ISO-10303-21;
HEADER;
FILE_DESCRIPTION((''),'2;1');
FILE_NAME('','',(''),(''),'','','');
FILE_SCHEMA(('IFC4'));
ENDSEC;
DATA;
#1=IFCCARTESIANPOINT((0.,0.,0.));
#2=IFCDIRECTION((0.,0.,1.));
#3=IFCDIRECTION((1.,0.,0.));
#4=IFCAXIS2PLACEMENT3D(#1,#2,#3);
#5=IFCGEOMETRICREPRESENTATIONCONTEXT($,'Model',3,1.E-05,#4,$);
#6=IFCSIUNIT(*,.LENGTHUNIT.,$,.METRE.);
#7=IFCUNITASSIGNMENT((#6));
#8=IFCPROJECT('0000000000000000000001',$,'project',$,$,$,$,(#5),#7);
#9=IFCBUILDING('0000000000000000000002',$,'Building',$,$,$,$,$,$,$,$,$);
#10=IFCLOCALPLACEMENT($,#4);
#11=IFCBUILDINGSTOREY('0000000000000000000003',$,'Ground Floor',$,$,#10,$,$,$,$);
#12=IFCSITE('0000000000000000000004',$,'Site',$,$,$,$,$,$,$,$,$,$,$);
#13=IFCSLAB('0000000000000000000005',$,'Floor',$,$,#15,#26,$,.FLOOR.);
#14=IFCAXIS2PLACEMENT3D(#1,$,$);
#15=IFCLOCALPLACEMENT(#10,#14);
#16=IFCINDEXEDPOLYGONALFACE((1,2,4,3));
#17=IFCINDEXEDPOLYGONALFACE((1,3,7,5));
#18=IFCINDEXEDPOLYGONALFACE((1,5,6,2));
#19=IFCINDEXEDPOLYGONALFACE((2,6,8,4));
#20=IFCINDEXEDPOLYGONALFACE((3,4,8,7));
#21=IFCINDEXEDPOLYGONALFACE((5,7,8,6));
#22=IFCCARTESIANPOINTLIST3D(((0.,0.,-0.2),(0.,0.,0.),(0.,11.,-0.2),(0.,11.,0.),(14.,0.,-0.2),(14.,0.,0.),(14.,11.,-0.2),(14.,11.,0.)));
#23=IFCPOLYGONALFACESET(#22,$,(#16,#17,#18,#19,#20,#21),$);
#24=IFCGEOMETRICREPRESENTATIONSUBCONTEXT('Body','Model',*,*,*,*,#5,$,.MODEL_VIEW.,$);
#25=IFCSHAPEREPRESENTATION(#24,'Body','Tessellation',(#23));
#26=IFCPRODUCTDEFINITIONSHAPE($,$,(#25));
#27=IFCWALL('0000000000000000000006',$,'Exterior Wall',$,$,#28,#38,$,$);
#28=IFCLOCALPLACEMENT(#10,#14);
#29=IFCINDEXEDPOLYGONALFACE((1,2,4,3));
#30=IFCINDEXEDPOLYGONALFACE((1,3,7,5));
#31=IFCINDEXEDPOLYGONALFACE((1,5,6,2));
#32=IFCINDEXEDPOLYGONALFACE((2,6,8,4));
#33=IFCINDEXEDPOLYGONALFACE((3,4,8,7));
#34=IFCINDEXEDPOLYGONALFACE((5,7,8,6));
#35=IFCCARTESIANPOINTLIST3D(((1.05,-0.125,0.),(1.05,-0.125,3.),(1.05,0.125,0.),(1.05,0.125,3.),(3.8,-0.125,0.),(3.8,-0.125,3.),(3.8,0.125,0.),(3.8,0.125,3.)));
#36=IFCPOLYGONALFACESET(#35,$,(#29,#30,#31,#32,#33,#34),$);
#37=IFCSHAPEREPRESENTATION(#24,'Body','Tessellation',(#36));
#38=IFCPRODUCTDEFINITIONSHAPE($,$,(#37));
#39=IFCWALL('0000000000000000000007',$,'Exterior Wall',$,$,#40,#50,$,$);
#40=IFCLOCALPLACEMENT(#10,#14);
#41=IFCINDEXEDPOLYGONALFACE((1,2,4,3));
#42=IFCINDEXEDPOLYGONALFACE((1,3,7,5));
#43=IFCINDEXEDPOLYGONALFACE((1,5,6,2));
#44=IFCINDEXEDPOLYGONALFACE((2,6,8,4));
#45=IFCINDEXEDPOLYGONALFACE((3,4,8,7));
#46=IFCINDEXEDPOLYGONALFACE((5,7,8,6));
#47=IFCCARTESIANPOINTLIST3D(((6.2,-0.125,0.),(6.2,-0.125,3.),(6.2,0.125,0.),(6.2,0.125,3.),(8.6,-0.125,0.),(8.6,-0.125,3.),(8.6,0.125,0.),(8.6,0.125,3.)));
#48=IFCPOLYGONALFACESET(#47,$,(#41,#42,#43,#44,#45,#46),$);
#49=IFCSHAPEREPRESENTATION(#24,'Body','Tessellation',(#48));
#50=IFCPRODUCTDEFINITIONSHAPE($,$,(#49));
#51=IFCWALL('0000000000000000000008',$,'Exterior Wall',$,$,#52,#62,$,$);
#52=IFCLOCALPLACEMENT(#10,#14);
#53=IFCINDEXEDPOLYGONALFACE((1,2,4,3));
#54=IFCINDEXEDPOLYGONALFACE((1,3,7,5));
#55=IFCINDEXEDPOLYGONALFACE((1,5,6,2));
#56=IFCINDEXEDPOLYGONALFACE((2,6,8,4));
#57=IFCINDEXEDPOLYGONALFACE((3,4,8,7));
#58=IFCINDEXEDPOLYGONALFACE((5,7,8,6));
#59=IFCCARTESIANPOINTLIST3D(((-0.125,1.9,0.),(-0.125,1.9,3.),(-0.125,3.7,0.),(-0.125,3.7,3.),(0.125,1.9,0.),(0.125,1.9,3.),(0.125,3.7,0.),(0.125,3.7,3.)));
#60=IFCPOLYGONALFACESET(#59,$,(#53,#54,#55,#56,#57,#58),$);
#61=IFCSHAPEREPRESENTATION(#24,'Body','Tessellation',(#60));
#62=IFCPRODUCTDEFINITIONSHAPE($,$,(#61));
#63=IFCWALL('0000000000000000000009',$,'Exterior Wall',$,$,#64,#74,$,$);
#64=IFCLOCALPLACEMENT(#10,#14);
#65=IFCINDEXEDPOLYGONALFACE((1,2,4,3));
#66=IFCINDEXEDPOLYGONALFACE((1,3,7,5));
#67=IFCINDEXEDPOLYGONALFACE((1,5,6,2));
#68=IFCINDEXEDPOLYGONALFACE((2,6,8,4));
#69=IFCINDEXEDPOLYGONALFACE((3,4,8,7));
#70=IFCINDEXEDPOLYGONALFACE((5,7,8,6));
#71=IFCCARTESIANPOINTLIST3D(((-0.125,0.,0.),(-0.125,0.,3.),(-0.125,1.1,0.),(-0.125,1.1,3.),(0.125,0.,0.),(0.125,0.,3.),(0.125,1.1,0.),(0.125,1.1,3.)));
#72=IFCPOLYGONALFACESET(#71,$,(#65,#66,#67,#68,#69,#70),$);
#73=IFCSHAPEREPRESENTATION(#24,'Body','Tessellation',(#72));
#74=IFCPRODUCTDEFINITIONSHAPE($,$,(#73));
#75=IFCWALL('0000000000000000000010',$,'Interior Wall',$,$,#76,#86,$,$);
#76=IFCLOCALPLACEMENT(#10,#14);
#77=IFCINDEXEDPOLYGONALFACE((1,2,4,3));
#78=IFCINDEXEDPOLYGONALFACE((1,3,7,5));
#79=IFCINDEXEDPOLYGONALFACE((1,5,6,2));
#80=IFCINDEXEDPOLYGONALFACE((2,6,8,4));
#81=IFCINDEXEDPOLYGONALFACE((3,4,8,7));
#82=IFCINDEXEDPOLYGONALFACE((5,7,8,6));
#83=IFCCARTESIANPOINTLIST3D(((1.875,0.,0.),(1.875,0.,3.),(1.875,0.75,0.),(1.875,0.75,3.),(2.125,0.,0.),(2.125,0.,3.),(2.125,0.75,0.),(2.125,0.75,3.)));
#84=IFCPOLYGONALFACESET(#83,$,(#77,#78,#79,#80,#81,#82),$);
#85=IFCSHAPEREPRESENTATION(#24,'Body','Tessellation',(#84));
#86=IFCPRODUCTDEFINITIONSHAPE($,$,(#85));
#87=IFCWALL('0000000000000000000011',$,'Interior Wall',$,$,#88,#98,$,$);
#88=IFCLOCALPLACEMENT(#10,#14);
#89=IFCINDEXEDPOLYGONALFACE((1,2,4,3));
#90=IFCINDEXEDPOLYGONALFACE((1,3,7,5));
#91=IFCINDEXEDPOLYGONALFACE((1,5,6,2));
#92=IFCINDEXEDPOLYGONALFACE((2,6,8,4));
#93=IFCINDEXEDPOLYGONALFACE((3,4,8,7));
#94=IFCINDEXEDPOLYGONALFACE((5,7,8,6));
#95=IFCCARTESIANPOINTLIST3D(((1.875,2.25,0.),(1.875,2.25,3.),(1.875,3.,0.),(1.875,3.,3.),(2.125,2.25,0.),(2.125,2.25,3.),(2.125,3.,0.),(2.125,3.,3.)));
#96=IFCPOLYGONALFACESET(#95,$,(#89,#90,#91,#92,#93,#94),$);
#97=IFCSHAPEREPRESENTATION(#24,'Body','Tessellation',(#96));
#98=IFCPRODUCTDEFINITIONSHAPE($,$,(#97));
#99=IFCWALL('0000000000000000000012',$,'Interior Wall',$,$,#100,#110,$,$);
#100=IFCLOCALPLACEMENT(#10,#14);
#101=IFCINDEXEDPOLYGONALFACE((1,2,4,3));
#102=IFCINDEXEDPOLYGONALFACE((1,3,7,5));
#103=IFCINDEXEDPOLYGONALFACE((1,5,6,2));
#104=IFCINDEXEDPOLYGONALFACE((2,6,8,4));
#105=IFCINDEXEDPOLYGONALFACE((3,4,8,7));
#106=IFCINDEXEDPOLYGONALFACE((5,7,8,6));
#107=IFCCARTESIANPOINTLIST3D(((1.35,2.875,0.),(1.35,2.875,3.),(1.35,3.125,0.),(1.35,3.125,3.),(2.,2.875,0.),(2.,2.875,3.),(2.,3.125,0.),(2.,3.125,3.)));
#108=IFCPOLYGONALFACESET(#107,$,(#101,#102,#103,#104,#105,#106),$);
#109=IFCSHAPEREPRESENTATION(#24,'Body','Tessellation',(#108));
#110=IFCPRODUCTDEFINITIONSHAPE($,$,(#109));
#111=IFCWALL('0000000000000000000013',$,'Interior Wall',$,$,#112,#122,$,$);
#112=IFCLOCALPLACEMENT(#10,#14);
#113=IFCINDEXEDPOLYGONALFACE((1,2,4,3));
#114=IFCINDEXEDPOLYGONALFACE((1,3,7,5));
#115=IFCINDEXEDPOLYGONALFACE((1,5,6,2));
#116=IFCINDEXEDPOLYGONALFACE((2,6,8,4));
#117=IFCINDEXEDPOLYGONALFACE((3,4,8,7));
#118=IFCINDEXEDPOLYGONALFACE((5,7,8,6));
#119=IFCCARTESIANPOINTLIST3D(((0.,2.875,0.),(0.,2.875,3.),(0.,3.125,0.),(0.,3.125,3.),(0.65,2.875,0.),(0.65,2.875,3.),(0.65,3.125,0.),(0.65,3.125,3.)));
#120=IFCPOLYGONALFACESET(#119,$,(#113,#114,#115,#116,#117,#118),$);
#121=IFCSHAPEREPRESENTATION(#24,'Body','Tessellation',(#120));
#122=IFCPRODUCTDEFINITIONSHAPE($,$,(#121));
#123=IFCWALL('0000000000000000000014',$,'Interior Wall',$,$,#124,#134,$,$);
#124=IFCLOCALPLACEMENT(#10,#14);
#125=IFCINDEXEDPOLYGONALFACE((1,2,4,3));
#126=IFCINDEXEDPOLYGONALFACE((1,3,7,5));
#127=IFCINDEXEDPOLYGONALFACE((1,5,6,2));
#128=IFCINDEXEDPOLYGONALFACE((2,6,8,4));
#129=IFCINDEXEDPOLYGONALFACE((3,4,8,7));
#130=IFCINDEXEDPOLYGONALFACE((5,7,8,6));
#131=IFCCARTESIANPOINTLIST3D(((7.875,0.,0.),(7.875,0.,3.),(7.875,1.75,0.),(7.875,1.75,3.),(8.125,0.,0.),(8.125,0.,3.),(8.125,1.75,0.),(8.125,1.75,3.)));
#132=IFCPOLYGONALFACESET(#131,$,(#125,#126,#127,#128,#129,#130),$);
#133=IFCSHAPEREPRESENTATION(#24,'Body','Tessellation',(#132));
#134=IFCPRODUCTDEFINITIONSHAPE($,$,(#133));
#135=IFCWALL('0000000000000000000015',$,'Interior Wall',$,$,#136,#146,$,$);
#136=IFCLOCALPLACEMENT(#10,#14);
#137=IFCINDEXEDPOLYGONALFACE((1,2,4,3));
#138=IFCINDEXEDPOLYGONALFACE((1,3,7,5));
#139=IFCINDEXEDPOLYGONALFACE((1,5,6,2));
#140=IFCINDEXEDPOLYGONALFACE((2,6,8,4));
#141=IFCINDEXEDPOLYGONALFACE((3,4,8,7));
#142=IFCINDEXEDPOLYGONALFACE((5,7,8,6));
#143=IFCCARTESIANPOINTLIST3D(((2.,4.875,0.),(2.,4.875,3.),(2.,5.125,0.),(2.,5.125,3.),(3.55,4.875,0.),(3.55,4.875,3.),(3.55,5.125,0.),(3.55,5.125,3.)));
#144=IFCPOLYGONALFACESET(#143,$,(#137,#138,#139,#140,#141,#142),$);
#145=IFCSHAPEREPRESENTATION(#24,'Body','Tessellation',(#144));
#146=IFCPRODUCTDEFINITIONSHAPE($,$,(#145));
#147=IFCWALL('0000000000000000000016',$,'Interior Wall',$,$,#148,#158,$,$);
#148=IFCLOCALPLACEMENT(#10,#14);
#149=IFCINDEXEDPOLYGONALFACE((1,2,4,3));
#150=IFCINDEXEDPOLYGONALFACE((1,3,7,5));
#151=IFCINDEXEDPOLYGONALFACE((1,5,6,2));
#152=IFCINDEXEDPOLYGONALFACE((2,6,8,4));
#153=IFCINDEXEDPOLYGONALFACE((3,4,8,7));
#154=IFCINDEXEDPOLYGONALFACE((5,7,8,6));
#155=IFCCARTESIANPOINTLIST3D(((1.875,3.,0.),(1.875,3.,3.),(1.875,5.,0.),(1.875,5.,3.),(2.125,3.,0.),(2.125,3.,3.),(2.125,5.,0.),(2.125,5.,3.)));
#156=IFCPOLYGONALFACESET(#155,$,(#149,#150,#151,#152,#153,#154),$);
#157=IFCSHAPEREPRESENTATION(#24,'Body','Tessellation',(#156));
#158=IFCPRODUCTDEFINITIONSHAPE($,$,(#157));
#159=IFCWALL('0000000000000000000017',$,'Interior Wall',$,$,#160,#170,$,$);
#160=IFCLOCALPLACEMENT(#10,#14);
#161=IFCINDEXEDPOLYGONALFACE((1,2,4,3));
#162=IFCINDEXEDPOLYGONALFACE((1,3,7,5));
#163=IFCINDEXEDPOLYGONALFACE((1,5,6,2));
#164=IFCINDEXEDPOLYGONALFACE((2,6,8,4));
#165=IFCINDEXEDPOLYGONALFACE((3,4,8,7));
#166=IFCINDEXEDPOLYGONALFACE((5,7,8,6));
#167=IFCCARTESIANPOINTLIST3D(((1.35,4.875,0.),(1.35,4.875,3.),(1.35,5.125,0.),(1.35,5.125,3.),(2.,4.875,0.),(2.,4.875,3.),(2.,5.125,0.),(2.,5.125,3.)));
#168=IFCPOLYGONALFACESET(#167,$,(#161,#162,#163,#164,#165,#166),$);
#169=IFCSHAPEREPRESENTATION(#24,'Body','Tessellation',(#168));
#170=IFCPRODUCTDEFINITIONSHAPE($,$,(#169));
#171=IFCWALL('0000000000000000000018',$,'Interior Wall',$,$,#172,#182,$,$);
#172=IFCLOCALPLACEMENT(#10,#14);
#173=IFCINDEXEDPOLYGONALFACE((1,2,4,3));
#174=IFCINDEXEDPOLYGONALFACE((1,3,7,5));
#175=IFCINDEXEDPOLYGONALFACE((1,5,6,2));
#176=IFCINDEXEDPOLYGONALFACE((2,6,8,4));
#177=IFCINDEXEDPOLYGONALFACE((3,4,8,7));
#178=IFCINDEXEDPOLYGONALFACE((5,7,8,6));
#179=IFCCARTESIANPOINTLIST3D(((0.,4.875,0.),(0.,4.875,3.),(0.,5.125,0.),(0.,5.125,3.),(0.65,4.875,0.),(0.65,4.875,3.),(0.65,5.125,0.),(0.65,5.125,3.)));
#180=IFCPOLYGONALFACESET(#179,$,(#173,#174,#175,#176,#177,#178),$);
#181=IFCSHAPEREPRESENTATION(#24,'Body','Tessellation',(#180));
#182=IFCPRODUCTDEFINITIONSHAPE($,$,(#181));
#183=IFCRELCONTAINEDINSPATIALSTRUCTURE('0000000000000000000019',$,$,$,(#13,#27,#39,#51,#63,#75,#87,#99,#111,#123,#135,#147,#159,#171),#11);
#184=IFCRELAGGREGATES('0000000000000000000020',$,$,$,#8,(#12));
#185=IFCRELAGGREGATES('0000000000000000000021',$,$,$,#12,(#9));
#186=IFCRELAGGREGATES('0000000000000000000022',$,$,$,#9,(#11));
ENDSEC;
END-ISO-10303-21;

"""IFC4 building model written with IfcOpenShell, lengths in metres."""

from ifc_helpers import new_model, si_unit, frame, origin_with_axes, place, context, subcontext, project, spatial, indexed_curve, outline, extrude, element, save


model = new_model("IFC4")

# Units and contexts
model_context = context("Model", 3, precision=1e-05, world=origin_with_axes())
body_context = subcontext(model_context, "Body", "Model", "MODEL_VIEW")
ifc_project = project(units=[si_unit("LENGTHUNIT", "METRE")], contexts=[model_context])

# Site, building, storey
site = spatial("IfcSite", under=ifc_project, Name="Site")
building = spatial("IfcBuilding", under=site, Name="Building")
storey_placement = place(None, origin_with_axes())
storey = spatial("IfcBuildingStorey", under=building, at=storey_placement, Name="Ground Floor")

# Slab
slab_placement = place(storey_placement, frame((0.0, 0.0, -0.2), z_axis=(0.0, 0.0, 1.0), x_axis=(1.0, 0.0, 0.0)))
element("IfcSlab", 1, at=slab_placement, inside=storey, Name="Floor", PredefinedType="FLOOR", context=body_context, shape_type="SweptSolid", body=[
    extrude(outline(indexed_curve([(0.0, 0.0), (14.0, 0.0), (14.0, 11.0), (0.0, 11.0)])), None, (0.0, 0.0, 1.0), 0.2),
])

# Walls
wall_1_placement = place(storey_placement, frame((1.05, 0.0, 0.0), z_axis=(0.0, 0.0, 1.0), x_axis=(1.0, 0.0, 0.0)))
element("IfcWall", 2, at=wall_1_placement, inside=storey, Name="Exterior Wall", context=body_context, shape_type="SweptSolid", body=[
    extrude(outline(indexed_curve([(0.0, 0.0), (0.0, 0.25), (2.75, 0.25), (2.75, 0.0), (0.0, 0.0)], self_intersect=False)), frame((0.0, -0.125, 0.0), z_axis=(0.0, 0.0, 1.0), x_axis=(1.0, 0.0, 0.0)), (0.0, 0.0, 1.0), 3.0),
])
wall_2_placement = place(storey_placement, frame((6.2, 0.0, 0.0), z_axis=(0.0, 0.0, 1.0), x_axis=(1.0, 0.0, 0.0)))
element("IfcWall", 3, at=wall_2_placement, inside=storey, Name="Exterior Wall", context=body_context, shape_type="SweptSolid", body=[
    extrude(outline(indexed_curve([(0.0, 0.0), (0.0, 0.25), (2.4, 0.25), (2.4, 0.0), (0.0, 0.0)], self_intersect=False)), frame((0.0, -0.125, 0.0), z_axis=(0.0, 0.0, 1.0), x_axis=(1.0, 0.0, 0.0)), (0.0, 0.0, 1.0), 3.0),
])
wall_3_placement = place(storey_placement, frame((0.0, 3.7, 0.0), z_axis=(0.0, 0.0, 1.0), x_axis=(0.0, -1.0, 0.0)))
element("IfcWall", 4, at=wall_3_placement, inside=storey, Name="Exterior Wall", context=body_context, shape_type="SweptSolid", body=[
    extrude(outline(indexed_curve([(0.0, 0.0), (0.0, 0.25), (1.8, 0.25), (1.8, 0.0), (0.0, 0.0)], self_intersect=False)), frame((0.0, -0.125, 0.0), z_axis=(0.0, 0.0, 1.0), x_axis=(1.0, 0.0, 0.0)), (0.0, 0.0, 1.0), 3.0),
])
wall_4_placement = place(storey_placement, frame((0.0, 1.1, 0.0), z_axis=(0.0, 0.0, 1.0), x_axis=(0.0, -1.0, 0.0)))
element("IfcWall", 5, at=wall_4_placement, inside=storey, Name="Exterior Wall", context=body_context, shape_type="SweptSolid", body=[
    extrude(outline(indexed_curve([(0.0, 0.0), (0.0, 0.25), (1.1, 0.25), (1.1, 0.0), (0.0, 0.0)], self_intersect=False)), frame((0.0, -0.125, 0.0), z_axis=(0.0, 0.0, 1.0), x_axis=(1.0, 0.0, 0.0)), (0.0, 0.0, 1.0), 3.0),
])
for number, where, z_axis, x_axis, name in (
    (6, (2.0, 0.0, 0.0), (0.0, 0.0, 1.0), (0.0, 1.0, 0.0), "Interior Wall"),
    (7, (2.0, 2.25, 0.0), (0.0, 0.0, 1.0), (0.0, 1.0, 0.0), "Interior Wall"),
):
    element("IfcWall", number, at=place(storey_placement, frame(where, z_axis=z_axis, x_axis=x_axis)), inside=storey, Name=name, context=body_context, shape_type="SweptSolid", body=[
        extrude(outline(indexed_curve([(0.0, 0.0), (0.0, 0.25), (0.75, 0.25), (0.75, 0.0), (0.0, 0.0)], self_intersect=False)), frame((0.0, -0.125, 0.0), z_axis=(0.0, 0.0, 1.0), x_axis=(1.0, 0.0, 0.0)), (0.0, 0.0, 1.0), 3.0),
    ])
for number, where, z_axis, x_axis, name in (
    (8, (2.0, 3.0, 0.0), (0.0, 0.0, 1.0), (-1.0, 0.0, 0.0), "Interior Wall"),
    (9, (0.65, 3.0, 0.0), (0.0, 0.0, 1.0), (-1.0, 0.0, 0.0), "Interior Wall"),
):
    element("IfcWall", number, at=place(storey_placement, frame(where, z_axis=z_axis, x_axis=x_axis)), inside=storey, Name=name, context=body_context, shape_type="SweptSolid", body=[
        extrude(outline(indexed_curve([(0.0, 0.0), (0.0, 0.25), (0.65, 0.25), (0.65, 0.0), (0.0, 0.0)], self_intersect=False)), frame((0.0, -0.125, 0.0), z_axis=(0.0, 0.0, 1.0), x_axis=(1.0, 0.0, 0.0)), (0.0, 0.0, 1.0), 3.0),
    ])
wall_5_placement = place(storey_placement, frame((8.0, 0.0, 0.0), z_axis=(0.0, 0.0, 1.0), x_axis=(0.0, 1.0, 0.0)))
element("IfcWall", 10, at=wall_5_placement, inside=storey, Name="Interior Wall", context=body_context, shape_type="SweptSolid", body=[
    extrude(outline(indexed_curve([(0.0, 0.0), (0.0, 0.25), (1.75, 0.25), (1.75, 0.0), (0.0, 0.0)], self_intersect=False)), frame((0.0, -0.125, 0.0), z_axis=(0.0, 0.0, 1.0), x_axis=(1.0, 0.0, 0.0)), (0.0, 0.0, 1.0), 3.0),
])
wall_6_placement = place(storey_placement, frame((3.55, 5.0, 0.0), z_axis=(0.0, 0.0, 1.0), x_axis=(-1.0, 0.0, 0.0)))
element("IfcWall", 11, at=wall_6_placement, inside=storey, Name="Interior Wall", context=body_context, shape_type="SweptSolid", body=[
    extrude(outline(indexed_curve([(0.0, 0.0), (0.0, 0.25), (1.55, 0.25), (1.55, 0.0), (0.0, 0.0)], self_intersect=False)), frame((0.0, -0.125, 0.0), z_axis=(0.0, 0.0, 1.0), x_axis=(1.0, 0.0, 0.0)), (0.0, 0.0, 1.0), 3.0),
])
wall_7_placement = place(storey_placement, frame((2.0, 5.0, 0.0), z_axis=(0.0, 0.0, 1.0), x_axis=(0.0, -1.0, 0.0)))
element("IfcWall", 12, at=wall_7_placement, inside=storey, Name="Interior Wall", context=body_context, shape_type="SweptSolid", body=[
    extrude(outline(indexed_curve([(0.0, 0.0), (0.0, 0.25), (2.0, 0.25), (2.0, 0.0), (0.0, 0.0)], self_intersect=False)), frame((0.0, -0.125, 0.0), z_axis=(0.0, 0.0, 1.0), x_axis=(1.0, 0.0, 0.0)), (0.0, 0.0, 1.0), 3.0),
])
for number, where, z_axis, x_axis, name in (
    (13, (2.0, 5.0, 0.0), (0.0, 0.0, 1.0), (-1.0, 0.0, 0.0), "Interior Wall"),
    (14, (0.65, 5.0, 0.0), (0.0, 0.0, 1.0), (-1.0, 0.0, 0.0), "Interior Wall"),
):
    element("IfcWall", number, at=place(storey_placement, frame(where, z_axis=z_axis, x_axis=x_axis)), inside=storey, Name=name, context=body_context, shape_type="SweptSolid", body=[
        extrude(outline(indexed_curve([(0.0, 0.0), (0.0, 0.25), (0.65, 0.25), (0.65, 0.0), (0.0, 0.0)], self_intersect=False)), frame((0.0, -0.125, 0.0), z_axis=(0.0, 0.0, 1.0), x_axis=(1.0, 0.0, 0.0)), (0.0, 0.0, 1.0), 3.0),
    ])

save(model, "model.ifc")
